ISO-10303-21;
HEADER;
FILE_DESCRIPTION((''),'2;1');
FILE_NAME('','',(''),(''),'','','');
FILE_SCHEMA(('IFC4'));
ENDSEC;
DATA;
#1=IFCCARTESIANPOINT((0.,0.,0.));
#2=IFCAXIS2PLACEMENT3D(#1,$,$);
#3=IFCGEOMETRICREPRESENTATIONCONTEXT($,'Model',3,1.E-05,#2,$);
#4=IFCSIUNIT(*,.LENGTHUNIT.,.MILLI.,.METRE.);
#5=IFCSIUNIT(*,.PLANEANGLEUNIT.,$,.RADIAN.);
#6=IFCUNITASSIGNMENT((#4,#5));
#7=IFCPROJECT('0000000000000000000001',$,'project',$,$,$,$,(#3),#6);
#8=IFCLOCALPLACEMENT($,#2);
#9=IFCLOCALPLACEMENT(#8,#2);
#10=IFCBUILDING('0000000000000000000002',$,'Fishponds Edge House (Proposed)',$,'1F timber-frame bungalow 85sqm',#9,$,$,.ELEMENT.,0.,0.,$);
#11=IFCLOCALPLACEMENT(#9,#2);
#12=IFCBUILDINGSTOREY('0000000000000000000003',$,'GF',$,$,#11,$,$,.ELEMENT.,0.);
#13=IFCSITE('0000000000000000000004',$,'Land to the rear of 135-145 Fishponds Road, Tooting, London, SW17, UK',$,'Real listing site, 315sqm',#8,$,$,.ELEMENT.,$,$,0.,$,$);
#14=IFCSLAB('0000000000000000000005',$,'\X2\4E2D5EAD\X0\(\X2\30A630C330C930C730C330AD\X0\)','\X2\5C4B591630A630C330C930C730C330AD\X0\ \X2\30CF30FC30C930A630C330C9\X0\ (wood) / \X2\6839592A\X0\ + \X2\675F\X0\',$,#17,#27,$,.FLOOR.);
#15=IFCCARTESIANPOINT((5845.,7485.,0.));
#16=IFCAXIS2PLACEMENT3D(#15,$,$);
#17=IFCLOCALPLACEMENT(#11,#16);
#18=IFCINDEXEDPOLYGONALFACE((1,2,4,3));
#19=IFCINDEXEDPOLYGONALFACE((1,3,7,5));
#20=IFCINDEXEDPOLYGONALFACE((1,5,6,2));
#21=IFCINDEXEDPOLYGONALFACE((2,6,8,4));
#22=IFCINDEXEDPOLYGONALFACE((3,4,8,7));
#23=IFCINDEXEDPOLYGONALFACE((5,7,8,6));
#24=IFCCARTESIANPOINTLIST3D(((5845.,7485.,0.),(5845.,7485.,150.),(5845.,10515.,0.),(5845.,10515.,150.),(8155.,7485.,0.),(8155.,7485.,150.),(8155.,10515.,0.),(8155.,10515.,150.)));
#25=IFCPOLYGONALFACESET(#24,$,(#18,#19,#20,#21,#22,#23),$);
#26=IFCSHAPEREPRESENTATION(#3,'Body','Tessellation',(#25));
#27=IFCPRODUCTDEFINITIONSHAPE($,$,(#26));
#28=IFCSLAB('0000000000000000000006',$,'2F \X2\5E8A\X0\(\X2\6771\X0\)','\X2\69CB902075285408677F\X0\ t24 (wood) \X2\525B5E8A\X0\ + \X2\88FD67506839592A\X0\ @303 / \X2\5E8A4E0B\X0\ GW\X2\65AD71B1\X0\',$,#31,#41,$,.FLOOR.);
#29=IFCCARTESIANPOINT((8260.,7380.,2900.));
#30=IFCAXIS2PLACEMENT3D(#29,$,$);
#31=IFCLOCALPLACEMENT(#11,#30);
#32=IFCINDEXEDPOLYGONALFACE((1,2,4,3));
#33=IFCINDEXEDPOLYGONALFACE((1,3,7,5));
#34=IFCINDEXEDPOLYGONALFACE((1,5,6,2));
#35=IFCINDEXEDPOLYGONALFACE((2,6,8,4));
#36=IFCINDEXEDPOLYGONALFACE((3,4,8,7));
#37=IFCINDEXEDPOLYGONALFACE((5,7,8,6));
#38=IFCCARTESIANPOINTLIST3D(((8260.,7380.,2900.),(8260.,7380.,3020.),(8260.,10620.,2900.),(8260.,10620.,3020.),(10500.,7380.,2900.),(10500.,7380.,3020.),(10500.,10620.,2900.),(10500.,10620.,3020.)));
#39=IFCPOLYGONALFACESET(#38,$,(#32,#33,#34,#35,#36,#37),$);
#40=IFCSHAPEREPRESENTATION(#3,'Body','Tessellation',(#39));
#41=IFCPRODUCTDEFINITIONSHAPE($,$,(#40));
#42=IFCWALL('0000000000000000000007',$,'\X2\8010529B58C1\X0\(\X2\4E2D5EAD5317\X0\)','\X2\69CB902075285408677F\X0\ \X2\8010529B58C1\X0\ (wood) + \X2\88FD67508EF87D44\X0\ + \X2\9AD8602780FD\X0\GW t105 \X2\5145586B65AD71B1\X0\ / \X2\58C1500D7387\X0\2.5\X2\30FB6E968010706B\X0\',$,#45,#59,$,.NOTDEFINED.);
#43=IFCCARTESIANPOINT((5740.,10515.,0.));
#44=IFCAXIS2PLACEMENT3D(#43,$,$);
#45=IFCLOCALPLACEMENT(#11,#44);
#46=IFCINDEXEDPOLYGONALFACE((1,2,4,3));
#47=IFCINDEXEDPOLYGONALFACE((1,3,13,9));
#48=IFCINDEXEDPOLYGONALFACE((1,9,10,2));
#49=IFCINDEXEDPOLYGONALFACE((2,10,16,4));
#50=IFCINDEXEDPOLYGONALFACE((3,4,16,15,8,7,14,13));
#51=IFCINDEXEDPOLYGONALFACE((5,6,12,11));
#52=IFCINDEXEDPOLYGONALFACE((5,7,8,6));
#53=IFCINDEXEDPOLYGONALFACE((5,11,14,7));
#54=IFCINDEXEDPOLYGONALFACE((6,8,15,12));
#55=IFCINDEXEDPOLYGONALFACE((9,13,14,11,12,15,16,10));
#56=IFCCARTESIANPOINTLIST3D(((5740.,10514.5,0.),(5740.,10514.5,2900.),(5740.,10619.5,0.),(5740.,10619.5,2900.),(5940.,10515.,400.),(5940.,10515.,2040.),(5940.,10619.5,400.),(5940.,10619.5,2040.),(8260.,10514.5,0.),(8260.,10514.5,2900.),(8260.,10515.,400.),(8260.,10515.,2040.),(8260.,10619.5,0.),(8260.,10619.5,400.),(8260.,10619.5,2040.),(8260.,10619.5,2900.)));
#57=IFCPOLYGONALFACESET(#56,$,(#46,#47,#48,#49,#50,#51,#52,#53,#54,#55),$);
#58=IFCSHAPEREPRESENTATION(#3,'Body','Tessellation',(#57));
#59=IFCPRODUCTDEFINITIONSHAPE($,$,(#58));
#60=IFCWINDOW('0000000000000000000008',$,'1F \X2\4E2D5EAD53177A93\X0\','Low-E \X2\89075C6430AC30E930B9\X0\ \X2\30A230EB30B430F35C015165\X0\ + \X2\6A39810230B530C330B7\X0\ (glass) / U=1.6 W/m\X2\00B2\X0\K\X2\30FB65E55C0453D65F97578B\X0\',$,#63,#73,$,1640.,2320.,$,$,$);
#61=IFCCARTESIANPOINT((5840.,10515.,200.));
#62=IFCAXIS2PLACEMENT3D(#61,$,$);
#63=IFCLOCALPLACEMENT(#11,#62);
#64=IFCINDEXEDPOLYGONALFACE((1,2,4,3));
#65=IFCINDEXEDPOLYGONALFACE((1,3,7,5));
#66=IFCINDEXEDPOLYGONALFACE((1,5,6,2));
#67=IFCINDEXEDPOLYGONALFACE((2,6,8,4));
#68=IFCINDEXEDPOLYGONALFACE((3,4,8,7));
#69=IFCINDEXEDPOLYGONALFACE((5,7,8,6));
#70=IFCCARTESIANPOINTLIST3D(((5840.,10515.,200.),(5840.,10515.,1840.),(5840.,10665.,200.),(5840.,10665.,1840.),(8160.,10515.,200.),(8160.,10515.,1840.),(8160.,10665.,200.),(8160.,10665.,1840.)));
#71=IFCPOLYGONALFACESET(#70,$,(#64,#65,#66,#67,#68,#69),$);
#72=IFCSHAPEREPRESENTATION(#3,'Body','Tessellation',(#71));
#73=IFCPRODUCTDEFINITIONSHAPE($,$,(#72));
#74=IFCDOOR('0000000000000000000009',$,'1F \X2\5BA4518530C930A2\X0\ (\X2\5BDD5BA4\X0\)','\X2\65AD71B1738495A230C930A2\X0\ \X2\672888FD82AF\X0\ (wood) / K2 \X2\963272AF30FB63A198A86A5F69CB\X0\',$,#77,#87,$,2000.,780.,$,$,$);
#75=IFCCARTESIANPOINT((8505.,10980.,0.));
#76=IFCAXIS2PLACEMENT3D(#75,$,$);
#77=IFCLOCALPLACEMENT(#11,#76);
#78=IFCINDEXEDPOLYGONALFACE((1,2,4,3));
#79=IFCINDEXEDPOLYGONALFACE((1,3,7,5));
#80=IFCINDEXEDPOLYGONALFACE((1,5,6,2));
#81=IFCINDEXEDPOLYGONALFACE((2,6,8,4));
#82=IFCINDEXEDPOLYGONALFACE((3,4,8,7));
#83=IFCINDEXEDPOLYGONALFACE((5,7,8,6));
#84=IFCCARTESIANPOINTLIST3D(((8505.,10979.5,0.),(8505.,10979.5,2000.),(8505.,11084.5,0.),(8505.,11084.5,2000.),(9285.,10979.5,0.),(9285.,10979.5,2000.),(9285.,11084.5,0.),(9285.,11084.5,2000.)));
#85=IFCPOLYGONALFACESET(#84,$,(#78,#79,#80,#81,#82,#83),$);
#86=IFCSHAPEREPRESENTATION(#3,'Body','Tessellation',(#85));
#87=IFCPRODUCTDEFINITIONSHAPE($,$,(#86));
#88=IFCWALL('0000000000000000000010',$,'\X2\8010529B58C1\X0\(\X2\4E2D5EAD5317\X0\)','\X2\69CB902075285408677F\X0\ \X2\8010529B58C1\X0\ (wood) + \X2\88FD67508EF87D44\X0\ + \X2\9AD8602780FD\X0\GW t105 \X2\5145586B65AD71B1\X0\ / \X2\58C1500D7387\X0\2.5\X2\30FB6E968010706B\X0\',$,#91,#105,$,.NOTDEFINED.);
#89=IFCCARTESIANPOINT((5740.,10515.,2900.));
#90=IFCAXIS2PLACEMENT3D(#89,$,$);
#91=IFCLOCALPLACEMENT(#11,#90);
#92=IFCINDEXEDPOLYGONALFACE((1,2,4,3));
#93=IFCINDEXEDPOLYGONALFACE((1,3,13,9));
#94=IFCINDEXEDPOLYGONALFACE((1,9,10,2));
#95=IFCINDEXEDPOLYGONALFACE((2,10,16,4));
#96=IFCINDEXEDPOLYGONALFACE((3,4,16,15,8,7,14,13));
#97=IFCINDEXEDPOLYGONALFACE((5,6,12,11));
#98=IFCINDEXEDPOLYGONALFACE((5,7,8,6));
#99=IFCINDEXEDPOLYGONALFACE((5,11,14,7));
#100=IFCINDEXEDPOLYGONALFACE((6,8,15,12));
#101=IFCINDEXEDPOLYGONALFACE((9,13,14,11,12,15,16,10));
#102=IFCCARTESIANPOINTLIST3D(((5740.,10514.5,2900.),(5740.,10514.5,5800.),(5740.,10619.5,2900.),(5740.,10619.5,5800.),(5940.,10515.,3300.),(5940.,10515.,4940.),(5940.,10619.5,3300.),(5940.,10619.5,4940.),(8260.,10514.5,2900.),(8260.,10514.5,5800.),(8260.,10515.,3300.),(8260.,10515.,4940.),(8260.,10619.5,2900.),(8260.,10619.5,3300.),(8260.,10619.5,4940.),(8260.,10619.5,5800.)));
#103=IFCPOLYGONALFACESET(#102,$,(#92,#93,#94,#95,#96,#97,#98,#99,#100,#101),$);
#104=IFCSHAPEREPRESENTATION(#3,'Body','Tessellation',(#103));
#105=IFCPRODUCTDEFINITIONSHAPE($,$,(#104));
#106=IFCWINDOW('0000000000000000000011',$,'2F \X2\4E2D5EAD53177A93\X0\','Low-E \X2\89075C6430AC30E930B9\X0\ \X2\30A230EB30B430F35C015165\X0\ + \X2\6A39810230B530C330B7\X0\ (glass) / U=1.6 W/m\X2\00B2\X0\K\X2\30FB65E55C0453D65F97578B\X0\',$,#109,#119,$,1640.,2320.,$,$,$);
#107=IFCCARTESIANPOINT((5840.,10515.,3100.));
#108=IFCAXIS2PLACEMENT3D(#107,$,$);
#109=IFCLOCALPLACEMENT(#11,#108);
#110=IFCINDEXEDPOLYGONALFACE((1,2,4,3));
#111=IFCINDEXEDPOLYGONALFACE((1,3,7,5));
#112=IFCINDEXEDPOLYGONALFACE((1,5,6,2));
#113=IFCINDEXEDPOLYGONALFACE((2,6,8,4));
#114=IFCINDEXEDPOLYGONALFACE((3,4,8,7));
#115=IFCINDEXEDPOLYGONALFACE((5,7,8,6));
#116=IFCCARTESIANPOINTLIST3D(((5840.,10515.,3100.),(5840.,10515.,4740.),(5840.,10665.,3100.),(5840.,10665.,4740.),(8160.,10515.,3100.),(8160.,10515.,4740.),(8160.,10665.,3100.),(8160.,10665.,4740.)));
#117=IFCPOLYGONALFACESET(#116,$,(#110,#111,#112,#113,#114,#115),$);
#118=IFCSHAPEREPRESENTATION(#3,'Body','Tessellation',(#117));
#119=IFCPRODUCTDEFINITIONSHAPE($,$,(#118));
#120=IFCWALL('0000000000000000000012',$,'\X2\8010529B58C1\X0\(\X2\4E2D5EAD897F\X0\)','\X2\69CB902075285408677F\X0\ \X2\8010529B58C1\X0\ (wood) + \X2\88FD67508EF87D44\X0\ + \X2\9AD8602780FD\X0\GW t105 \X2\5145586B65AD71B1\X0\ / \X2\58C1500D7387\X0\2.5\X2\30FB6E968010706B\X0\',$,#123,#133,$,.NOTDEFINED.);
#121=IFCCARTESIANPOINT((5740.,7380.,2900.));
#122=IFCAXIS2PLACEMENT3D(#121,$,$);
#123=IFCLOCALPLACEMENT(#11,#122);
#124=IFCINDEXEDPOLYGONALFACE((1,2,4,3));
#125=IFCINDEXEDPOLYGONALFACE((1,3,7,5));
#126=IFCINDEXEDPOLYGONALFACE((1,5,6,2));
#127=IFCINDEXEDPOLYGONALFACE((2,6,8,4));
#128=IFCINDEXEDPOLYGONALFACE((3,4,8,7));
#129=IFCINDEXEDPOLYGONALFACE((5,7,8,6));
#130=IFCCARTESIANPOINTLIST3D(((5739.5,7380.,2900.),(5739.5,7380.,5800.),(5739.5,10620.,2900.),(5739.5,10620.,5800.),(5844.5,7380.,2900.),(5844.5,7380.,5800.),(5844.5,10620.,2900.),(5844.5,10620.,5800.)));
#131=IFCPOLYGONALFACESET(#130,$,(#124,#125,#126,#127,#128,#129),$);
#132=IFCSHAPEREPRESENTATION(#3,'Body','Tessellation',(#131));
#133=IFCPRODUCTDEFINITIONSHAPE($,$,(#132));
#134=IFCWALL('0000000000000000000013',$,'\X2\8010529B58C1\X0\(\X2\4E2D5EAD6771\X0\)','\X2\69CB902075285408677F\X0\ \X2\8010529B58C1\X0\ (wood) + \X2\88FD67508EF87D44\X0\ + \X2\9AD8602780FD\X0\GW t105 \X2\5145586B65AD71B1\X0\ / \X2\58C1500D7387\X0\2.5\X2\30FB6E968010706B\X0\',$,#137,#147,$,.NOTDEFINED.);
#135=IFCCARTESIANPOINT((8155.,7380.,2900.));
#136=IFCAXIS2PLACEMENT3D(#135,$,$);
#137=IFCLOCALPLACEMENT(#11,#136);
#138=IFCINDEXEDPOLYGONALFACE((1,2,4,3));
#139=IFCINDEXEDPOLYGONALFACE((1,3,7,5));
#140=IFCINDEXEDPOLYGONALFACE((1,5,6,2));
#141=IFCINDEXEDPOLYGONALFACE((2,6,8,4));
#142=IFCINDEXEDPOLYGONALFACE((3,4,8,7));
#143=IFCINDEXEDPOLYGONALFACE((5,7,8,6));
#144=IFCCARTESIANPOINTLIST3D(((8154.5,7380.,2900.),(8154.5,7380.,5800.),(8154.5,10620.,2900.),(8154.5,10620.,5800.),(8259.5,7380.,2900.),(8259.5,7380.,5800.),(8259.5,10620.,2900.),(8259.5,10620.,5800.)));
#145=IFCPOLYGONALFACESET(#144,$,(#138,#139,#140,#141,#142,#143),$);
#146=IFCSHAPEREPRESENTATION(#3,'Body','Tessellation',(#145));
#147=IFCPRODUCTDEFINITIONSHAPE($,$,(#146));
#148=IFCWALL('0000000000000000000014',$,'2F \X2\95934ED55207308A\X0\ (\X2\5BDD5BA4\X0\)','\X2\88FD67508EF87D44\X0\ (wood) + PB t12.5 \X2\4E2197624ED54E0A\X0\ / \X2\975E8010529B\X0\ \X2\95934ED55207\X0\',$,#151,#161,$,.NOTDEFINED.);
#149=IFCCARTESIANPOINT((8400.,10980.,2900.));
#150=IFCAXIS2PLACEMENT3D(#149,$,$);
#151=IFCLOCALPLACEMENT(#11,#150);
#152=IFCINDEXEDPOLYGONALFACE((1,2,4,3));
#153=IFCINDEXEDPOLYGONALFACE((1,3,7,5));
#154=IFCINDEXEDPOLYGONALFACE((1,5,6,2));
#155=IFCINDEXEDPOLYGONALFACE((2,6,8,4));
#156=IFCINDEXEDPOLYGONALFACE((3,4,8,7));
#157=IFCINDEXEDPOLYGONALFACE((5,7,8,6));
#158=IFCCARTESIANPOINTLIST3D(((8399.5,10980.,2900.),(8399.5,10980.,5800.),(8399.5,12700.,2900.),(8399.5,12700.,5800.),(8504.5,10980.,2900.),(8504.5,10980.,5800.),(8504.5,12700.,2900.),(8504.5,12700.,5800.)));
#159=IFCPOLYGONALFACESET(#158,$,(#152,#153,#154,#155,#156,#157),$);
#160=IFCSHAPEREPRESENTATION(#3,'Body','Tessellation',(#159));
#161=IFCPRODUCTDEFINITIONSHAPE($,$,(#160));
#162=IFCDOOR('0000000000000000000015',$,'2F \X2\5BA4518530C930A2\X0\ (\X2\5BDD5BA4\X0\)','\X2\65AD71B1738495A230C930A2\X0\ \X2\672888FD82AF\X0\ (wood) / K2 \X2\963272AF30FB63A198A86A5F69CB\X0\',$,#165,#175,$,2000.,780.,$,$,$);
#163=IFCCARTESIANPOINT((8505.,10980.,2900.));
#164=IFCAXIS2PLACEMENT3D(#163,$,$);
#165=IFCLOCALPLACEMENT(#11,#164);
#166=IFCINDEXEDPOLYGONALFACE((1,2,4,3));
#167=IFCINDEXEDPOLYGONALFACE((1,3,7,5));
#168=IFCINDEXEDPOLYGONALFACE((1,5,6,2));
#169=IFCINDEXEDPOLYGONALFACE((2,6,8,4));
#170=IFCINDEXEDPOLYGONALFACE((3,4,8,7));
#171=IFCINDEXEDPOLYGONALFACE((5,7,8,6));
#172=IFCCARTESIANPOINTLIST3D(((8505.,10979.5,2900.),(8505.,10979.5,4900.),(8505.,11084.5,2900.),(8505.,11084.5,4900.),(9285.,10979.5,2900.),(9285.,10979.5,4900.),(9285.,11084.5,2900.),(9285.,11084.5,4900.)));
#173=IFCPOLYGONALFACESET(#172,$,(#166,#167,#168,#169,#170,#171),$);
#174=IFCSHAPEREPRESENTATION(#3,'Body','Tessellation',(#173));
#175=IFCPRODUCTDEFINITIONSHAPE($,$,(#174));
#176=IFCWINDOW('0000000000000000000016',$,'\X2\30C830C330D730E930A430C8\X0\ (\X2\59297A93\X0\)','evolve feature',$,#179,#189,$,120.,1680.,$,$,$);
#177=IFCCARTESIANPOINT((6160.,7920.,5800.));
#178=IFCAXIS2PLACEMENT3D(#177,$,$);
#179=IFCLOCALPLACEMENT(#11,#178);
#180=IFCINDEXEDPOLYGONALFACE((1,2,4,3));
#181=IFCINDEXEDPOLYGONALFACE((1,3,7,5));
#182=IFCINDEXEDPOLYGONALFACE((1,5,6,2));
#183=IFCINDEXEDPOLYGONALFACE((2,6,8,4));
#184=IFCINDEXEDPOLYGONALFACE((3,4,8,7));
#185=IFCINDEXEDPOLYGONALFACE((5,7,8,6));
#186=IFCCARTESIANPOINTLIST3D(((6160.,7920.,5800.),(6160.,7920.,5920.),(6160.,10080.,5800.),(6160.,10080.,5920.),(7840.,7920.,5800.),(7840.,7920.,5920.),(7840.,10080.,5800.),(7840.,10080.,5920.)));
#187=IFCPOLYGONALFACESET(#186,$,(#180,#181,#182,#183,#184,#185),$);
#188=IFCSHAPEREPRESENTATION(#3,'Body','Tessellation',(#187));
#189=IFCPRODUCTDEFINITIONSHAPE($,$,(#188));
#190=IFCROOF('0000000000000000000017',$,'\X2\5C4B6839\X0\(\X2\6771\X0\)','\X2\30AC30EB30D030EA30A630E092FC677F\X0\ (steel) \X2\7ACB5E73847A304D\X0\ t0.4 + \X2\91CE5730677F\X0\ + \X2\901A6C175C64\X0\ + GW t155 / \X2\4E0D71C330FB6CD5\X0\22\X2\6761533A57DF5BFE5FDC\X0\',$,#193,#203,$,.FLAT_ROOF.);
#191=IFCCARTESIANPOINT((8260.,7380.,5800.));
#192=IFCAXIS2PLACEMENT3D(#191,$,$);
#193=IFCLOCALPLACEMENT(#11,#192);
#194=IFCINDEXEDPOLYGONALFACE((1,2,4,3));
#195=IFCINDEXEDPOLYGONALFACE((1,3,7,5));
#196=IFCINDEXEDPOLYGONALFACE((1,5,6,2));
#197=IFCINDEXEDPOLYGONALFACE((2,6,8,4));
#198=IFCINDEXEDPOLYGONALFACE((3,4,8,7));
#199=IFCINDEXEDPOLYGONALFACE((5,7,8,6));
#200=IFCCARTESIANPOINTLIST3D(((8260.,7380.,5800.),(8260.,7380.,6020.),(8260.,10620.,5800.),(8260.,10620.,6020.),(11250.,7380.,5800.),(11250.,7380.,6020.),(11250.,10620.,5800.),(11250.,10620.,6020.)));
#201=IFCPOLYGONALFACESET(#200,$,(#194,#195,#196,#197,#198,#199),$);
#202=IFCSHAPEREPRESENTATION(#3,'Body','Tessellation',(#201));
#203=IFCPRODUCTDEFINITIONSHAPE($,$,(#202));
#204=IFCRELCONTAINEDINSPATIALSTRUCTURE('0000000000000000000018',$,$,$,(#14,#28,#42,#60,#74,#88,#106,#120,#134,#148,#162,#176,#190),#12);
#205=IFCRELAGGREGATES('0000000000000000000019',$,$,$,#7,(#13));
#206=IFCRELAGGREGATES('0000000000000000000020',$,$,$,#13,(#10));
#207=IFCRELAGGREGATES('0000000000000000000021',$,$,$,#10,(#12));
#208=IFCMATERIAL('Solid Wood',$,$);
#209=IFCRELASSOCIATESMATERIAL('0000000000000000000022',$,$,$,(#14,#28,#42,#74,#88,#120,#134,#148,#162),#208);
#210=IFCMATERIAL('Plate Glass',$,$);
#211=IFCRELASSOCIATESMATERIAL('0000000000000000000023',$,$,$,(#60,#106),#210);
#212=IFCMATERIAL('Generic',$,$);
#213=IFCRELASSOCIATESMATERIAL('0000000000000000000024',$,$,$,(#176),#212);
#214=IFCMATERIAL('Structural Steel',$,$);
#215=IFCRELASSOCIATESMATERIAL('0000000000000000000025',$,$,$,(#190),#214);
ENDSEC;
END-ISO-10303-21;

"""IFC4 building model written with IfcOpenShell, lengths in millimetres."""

from ifc_helpers import new_model, si_unit, frame, frame_2d, origin, place, context, project, spatial, rectangle, extrude, material, element, fill, save


model = new_model("IFC4")

# Units and contexts
model_context = context("Model", 3, precision=1e-05, world=origin())
ifc_project = project(units=[si_unit("LENGTHUNIT", "METRE", prefix="MILLI"), si_unit("PLANEANGLEUNIT", "RADIAN")], contexts=[model_context])

# Site, building, storey
site_placement = place(None, origin())
site = spatial("IfcSite", under=ifc_project, at=site_placement, Name="Land to the rear of 135-145 Fishponds Road, Tooting, London, SW17, UK", ObjectType="Real listing site, 315sqm", CompositionType="ELEMENT", RefElevation=0.0)
building_placement = place(site_placement, origin())
building = spatial("IfcBuilding", under=site, at=building_placement, Name="Fishponds Edge House (Proposed)", ObjectType="1F timber-frame bungalow 85sqm", CompositionType="ELEMENT", ElevationOfRefHeight=0.0, ElevationOfTerrain=0.0)
storey_placement = place(building_placement, origin())
storey = spatial("IfcBuildingStorey", under=building, at=storey_placement, Name="GF", CompositionType="ELEMENT", Elevation=0.0)

# Slabs
ifc_material_1 = material(Name="Solid Wood")
slab_1_placement = place(storey_placement, frame((5845.0, 7485.0, 0.0)))
element("IfcSlab", 1, at=slab_1_placement, inside=storey, material=ifc_material_1, Name="中庭(ウッドデッキ)", Description="屋外ウッドデッキ ハードウッド (wood) / 根太 + 束", PredefinedType="FLOOR", context=model_context, shape_type="SweptSolid", body=[
    extrude(rectangle(XDim=2310.0, YDim=3030.0, at=frame_2d((1155.0, 1515.0))), frame((5845.0, 7485.0, 0.0)), (0.0, 0.0, 1.0), 150.0),
])
slab_2_placement = place(storey_placement, frame((8260.0, 7380.0, 2900.0)))
element("IfcSlab", 2, at=slab_2_placement, inside=storey, material=ifc_material_1, Name="2F 床(東)", Description="構造用合板 t24 (wood) 剛床 + 製材根太 @303 / 床下 GW断熱", PredefinedType="FLOOR", context=model_context, shape_type="SweptSolid", body=[
    extrude(rectangle(XDim=2240.0, YDim=3240.0, at=frame_2d((1120.0, 1620.0))), frame((8260.0, 7380.0, 2900.0)), (0.0, 0.0, 1.0), 120.0),
])

# Wall, opening, window
wall_1_placement = place(storey_placement, frame((5740.0, 10515.0, 0.0)))
wall_1 = element("IfcWall", 3, at=wall_1_placement, inside=storey, material=ifc_material_1, Name="耐力壁(中庭北)", Description="構造用合板 耐力壁 (wood) + 製材軸組 + 高性能GW t105 充填断熱 / 壁倍率2.5・準耐火", PredefinedType="NOTDEFINED", context=model_context, shape_type="SweptSolid", body=[
    extrude(rectangle(XDim=2520.0, YDim=105.0, at=frame_2d((1260.0, 52.0))), frame((5740.0, 10515.0, 0.0)), (0.0, 0.0, 1.0), 2900.0),
])
opening_1_placement = place(storey_placement, frame((5840.0, 10515.0, 200.0)))
opening_1 = element("IfcOpeningElement", 4, at=opening_1_placement, cuts=wall_1, PredefinedType="NOTDEFINED", context=model_context, shape_type="SweptSolid", body=[
    extrude(rectangle(XDim=2320.0, YDim=150.0, at=frame_2d((1160.0, 75.0))), frame((5840.0, 10515.0, 200.0)), (0.0, 0.0, 1.0), 1640.0),
])
ifc_material_2 = material(Name="Plate Glass")
window_1_placement = place(storey_placement, frame((5840.0, 10515.0, 200.0)))
window_1 = element("IfcWindow", 5, at=window_1_placement, inside=storey, material=ifc_material_2, Name="1F 中庭北窓", Description="Low-E 複層ガラス アルゴン封入 + 樹脂サッシ (glass) / U=1.6 W/m²K・日射取得型", OverallHeight=1640.0, OverallWidth=2320.0, context=model_context, shape_type="SweptSolid", body=[
    extrude(rectangle(XDim=2320.0, YDim=150.0, at=frame_2d((1160.0, 75.0))), frame((5840.0, 10515.0, 200.0)), (0.0, 0.0, 1.0), 1640.0),
])
fill(opening_1, window_1)

# Door
door_1_placement = place(storey_placement, frame((8505.0, 10980.0, 0.0)))
element("IfcDoor", 6, at=door_1_placement, inside=storey, material=ifc_material_1, Name="1F 室内ドア (寝室)", Description="断熱玄関ドア 木製芯 (wood) / K2 防犯・採風機構", OverallHeight=2000.0, OverallWidth=780.0, context=model_context, shape_type="SweptSolid", body=[
    extrude(rectangle(XDim=780.0, YDim=105.0, at=frame_2d((390.0, 52.0))), frame((8505.0, 10980.0, 0.0)), (0.0, 0.0, 1.0), 2000.0),
])

# Wall, opening, window
wall_2_placement = place(storey_placement, frame((5740.0, 10515.0, 2900.0)))
wall_2 = element("IfcWall", 7, at=wall_2_placement, inside=storey, material=ifc_material_1, Name="耐力壁(中庭北)", Description="構造用合板 耐力壁 (wood) + 製材軸組 + 高性能GW t105 充填断熱 / 壁倍率2.5・準耐火", PredefinedType="NOTDEFINED", context=model_context, shape_type="SweptSolid", body=[
    extrude(rectangle(XDim=2520.0, YDim=105.0, at=frame_2d((1260.0, 52.0))), frame((5740.0, 10515.0, 2900.0)), (0.0, 0.0, 1.0), 2900.0),
])
opening_2_placement = place(storey_placement, frame((5840.0, 10515.0, 3100.0)))
opening_2 = element("IfcOpeningElement", 8, at=opening_2_placement, cuts=wall_2, PredefinedType="NOTDEFINED", context=model_context, shape_type="SweptSolid", body=[
    extrude(rectangle(XDim=2320.0, YDim=150.0, at=frame_2d((1160.0, 75.0))), frame((5840.0, 10515.0, 3100.0)), (0.0, 0.0, 1.0), 1640.0),
])
window_2_placement = place(storey_placement, frame((5840.0, 10515.0, 3100.0)))
window_2 = element("IfcWindow", 9, at=window_2_placement, inside=storey, material=ifc_material_2, Name="2F 中庭北窓", Description="Low-E 複層ガラス アルゴン封入 + 樹脂サッシ (glass) / U=1.6 W/m²K・日射取得型", OverallHeight=1640.0, OverallWidth=2320.0, context=model_context, shape_type="SweptSolid", body=[
    extrude(rectangle(XDim=2320.0, YDim=150.0, at=frame_2d((1160.0, 75.0))), frame((5840.0, 10515.0, 3100.0)), (0.0, 0.0, 1.0), 1640.0),
])
fill(opening_2, window_2)

# Walls
wall_3_placement = place(storey_placement, frame((5740.0, 7380.0, 2900.0)))
element("IfcWall", 10, at=wall_3_placement, inside=storey, material=ifc_material_1, Name="耐力壁(中庭西)", Description="構造用合板 耐力壁 (wood) + 製材軸組 + 高性能GW t105 充填断熱 / 壁倍率2.5・準耐火", PredefinedType="NOTDEFINED", context=model_context, shape_type="SweptSolid", body=[
    extrude(rectangle(XDim=105.0, YDim=3240.0, at=frame_2d((52.0, 1620.0))), frame((5740.0, 7380.0, 2900.0)), (0.0, 0.0, 1.0), 2900.0),
])
wall_4_placement = place(storey_placement, frame((8155.0, 7380.0, 2900.0)))
element("IfcWall", 11, at=wall_4_placement, inside=storey, material=ifc_material_1, Name="耐力壁(中庭東)", Description="構造用合板 耐力壁 (wood) + 製材軸組 + 高性能GW t105 充填断熱 / 壁倍率2.5・準耐火", PredefinedType="NOTDEFINED", context=model_context, shape_type="SweptSolid", body=[
    extrude(rectangle(XDim=105.0, YDim=3240.0, at=frame_2d((52.0, 1620.0))), frame((8155.0, 7380.0, 2900.0)), (0.0, 0.0, 1.0), 2900.0),
])
wall_5_placement = place(storey_placement, frame((8400.0, 10980.0, 2900.0)))
element("IfcWall", 12, at=wall_5_placement, inside=storey, material=ifc_material_1, Name="2F 間仕切り (寝室)", Description="製材軸組 (wood) + PB t12.5 両面仕上 / 非耐力 間仕切", PredefinedType="NOTDEFINED", context=model_context, shape_type="SweptSolid", body=[
    extrude(rectangle(XDim=105.0, YDim=1720.0, at=frame_2d((52.0, 860.0))), frame((8400.0, 10980.0, 2900.0)), (0.0, 0.0, 1.0), 2900.0),
])

# Door
door_2_placement = place(storey_placement, frame((8505.0, 10980.0, 2900.0)))
element("IfcDoor", 13, at=door_2_placement, inside=storey, material=ifc_material_1, Name="2F 室内ドア (寝室)", Description="断熱玄関ドア 木製芯 (wood) / K2 防犯・採風機構", OverallHeight=2000.0, OverallWidth=780.0, context=model_context, shape_type="SweptSolid", body=[
    extrude(rectangle(XDim=780.0, YDim=105.0, at=frame_2d((390.0, 52.0))), frame((8505.0, 10980.0, 2900.0)), (0.0, 0.0, 1.0), 2000.0),
])

# Window
ifc_material_3 = material(Name="Generic")
window_3_placement = place(storey_placement, frame((6160.0, 7920.0, 5800.0)))
element("IfcWindow", 14, at=window_3_placement, inside=storey, material=ifc_material_3, Name="トップライト (天窓)", Description="evolve feature", OverallHeight=120.0, OverallWidth=1680.0, context=model_context, shape_type="SweptSolid", body=[
    extrude(rectangle(XDim=1680.0, YDim=2160.0, at=frame_2d((840.0, 1080.0))), frame((6160.0, 7920.0, 5800.0)), (0.0, 0.0, 1.0), 120.0),
])

# Roof
ifc_material_4 = material(Name="Structural Steel")
roof_placement = place(storey_placement, frame((8260.0, 7380.0, 5800.0)))
element("IfcRoof", 15, at=roof_placement, inside=storey, material=ifc_material_4, Name="屋根(東)", Description="ガルバリウム鋼板 (steel) 立平葺き t0.4 + 野地板 + 通気層 + GW t155 / 不燃・法22条区域対応", PredefinedType="FLAT_ROOF", context=model_context, shape_type="SweptSolid", body=[
    extrude(rectangle(XDim=2990.0, YDim=3240.0, at=frame_2d((1495.0, 1620.0))), frame((8260.0, 7380.0, 5800.0)), (0.0, 0.0, 1.0), 220.0),
])

save(model, "model.ifc")
